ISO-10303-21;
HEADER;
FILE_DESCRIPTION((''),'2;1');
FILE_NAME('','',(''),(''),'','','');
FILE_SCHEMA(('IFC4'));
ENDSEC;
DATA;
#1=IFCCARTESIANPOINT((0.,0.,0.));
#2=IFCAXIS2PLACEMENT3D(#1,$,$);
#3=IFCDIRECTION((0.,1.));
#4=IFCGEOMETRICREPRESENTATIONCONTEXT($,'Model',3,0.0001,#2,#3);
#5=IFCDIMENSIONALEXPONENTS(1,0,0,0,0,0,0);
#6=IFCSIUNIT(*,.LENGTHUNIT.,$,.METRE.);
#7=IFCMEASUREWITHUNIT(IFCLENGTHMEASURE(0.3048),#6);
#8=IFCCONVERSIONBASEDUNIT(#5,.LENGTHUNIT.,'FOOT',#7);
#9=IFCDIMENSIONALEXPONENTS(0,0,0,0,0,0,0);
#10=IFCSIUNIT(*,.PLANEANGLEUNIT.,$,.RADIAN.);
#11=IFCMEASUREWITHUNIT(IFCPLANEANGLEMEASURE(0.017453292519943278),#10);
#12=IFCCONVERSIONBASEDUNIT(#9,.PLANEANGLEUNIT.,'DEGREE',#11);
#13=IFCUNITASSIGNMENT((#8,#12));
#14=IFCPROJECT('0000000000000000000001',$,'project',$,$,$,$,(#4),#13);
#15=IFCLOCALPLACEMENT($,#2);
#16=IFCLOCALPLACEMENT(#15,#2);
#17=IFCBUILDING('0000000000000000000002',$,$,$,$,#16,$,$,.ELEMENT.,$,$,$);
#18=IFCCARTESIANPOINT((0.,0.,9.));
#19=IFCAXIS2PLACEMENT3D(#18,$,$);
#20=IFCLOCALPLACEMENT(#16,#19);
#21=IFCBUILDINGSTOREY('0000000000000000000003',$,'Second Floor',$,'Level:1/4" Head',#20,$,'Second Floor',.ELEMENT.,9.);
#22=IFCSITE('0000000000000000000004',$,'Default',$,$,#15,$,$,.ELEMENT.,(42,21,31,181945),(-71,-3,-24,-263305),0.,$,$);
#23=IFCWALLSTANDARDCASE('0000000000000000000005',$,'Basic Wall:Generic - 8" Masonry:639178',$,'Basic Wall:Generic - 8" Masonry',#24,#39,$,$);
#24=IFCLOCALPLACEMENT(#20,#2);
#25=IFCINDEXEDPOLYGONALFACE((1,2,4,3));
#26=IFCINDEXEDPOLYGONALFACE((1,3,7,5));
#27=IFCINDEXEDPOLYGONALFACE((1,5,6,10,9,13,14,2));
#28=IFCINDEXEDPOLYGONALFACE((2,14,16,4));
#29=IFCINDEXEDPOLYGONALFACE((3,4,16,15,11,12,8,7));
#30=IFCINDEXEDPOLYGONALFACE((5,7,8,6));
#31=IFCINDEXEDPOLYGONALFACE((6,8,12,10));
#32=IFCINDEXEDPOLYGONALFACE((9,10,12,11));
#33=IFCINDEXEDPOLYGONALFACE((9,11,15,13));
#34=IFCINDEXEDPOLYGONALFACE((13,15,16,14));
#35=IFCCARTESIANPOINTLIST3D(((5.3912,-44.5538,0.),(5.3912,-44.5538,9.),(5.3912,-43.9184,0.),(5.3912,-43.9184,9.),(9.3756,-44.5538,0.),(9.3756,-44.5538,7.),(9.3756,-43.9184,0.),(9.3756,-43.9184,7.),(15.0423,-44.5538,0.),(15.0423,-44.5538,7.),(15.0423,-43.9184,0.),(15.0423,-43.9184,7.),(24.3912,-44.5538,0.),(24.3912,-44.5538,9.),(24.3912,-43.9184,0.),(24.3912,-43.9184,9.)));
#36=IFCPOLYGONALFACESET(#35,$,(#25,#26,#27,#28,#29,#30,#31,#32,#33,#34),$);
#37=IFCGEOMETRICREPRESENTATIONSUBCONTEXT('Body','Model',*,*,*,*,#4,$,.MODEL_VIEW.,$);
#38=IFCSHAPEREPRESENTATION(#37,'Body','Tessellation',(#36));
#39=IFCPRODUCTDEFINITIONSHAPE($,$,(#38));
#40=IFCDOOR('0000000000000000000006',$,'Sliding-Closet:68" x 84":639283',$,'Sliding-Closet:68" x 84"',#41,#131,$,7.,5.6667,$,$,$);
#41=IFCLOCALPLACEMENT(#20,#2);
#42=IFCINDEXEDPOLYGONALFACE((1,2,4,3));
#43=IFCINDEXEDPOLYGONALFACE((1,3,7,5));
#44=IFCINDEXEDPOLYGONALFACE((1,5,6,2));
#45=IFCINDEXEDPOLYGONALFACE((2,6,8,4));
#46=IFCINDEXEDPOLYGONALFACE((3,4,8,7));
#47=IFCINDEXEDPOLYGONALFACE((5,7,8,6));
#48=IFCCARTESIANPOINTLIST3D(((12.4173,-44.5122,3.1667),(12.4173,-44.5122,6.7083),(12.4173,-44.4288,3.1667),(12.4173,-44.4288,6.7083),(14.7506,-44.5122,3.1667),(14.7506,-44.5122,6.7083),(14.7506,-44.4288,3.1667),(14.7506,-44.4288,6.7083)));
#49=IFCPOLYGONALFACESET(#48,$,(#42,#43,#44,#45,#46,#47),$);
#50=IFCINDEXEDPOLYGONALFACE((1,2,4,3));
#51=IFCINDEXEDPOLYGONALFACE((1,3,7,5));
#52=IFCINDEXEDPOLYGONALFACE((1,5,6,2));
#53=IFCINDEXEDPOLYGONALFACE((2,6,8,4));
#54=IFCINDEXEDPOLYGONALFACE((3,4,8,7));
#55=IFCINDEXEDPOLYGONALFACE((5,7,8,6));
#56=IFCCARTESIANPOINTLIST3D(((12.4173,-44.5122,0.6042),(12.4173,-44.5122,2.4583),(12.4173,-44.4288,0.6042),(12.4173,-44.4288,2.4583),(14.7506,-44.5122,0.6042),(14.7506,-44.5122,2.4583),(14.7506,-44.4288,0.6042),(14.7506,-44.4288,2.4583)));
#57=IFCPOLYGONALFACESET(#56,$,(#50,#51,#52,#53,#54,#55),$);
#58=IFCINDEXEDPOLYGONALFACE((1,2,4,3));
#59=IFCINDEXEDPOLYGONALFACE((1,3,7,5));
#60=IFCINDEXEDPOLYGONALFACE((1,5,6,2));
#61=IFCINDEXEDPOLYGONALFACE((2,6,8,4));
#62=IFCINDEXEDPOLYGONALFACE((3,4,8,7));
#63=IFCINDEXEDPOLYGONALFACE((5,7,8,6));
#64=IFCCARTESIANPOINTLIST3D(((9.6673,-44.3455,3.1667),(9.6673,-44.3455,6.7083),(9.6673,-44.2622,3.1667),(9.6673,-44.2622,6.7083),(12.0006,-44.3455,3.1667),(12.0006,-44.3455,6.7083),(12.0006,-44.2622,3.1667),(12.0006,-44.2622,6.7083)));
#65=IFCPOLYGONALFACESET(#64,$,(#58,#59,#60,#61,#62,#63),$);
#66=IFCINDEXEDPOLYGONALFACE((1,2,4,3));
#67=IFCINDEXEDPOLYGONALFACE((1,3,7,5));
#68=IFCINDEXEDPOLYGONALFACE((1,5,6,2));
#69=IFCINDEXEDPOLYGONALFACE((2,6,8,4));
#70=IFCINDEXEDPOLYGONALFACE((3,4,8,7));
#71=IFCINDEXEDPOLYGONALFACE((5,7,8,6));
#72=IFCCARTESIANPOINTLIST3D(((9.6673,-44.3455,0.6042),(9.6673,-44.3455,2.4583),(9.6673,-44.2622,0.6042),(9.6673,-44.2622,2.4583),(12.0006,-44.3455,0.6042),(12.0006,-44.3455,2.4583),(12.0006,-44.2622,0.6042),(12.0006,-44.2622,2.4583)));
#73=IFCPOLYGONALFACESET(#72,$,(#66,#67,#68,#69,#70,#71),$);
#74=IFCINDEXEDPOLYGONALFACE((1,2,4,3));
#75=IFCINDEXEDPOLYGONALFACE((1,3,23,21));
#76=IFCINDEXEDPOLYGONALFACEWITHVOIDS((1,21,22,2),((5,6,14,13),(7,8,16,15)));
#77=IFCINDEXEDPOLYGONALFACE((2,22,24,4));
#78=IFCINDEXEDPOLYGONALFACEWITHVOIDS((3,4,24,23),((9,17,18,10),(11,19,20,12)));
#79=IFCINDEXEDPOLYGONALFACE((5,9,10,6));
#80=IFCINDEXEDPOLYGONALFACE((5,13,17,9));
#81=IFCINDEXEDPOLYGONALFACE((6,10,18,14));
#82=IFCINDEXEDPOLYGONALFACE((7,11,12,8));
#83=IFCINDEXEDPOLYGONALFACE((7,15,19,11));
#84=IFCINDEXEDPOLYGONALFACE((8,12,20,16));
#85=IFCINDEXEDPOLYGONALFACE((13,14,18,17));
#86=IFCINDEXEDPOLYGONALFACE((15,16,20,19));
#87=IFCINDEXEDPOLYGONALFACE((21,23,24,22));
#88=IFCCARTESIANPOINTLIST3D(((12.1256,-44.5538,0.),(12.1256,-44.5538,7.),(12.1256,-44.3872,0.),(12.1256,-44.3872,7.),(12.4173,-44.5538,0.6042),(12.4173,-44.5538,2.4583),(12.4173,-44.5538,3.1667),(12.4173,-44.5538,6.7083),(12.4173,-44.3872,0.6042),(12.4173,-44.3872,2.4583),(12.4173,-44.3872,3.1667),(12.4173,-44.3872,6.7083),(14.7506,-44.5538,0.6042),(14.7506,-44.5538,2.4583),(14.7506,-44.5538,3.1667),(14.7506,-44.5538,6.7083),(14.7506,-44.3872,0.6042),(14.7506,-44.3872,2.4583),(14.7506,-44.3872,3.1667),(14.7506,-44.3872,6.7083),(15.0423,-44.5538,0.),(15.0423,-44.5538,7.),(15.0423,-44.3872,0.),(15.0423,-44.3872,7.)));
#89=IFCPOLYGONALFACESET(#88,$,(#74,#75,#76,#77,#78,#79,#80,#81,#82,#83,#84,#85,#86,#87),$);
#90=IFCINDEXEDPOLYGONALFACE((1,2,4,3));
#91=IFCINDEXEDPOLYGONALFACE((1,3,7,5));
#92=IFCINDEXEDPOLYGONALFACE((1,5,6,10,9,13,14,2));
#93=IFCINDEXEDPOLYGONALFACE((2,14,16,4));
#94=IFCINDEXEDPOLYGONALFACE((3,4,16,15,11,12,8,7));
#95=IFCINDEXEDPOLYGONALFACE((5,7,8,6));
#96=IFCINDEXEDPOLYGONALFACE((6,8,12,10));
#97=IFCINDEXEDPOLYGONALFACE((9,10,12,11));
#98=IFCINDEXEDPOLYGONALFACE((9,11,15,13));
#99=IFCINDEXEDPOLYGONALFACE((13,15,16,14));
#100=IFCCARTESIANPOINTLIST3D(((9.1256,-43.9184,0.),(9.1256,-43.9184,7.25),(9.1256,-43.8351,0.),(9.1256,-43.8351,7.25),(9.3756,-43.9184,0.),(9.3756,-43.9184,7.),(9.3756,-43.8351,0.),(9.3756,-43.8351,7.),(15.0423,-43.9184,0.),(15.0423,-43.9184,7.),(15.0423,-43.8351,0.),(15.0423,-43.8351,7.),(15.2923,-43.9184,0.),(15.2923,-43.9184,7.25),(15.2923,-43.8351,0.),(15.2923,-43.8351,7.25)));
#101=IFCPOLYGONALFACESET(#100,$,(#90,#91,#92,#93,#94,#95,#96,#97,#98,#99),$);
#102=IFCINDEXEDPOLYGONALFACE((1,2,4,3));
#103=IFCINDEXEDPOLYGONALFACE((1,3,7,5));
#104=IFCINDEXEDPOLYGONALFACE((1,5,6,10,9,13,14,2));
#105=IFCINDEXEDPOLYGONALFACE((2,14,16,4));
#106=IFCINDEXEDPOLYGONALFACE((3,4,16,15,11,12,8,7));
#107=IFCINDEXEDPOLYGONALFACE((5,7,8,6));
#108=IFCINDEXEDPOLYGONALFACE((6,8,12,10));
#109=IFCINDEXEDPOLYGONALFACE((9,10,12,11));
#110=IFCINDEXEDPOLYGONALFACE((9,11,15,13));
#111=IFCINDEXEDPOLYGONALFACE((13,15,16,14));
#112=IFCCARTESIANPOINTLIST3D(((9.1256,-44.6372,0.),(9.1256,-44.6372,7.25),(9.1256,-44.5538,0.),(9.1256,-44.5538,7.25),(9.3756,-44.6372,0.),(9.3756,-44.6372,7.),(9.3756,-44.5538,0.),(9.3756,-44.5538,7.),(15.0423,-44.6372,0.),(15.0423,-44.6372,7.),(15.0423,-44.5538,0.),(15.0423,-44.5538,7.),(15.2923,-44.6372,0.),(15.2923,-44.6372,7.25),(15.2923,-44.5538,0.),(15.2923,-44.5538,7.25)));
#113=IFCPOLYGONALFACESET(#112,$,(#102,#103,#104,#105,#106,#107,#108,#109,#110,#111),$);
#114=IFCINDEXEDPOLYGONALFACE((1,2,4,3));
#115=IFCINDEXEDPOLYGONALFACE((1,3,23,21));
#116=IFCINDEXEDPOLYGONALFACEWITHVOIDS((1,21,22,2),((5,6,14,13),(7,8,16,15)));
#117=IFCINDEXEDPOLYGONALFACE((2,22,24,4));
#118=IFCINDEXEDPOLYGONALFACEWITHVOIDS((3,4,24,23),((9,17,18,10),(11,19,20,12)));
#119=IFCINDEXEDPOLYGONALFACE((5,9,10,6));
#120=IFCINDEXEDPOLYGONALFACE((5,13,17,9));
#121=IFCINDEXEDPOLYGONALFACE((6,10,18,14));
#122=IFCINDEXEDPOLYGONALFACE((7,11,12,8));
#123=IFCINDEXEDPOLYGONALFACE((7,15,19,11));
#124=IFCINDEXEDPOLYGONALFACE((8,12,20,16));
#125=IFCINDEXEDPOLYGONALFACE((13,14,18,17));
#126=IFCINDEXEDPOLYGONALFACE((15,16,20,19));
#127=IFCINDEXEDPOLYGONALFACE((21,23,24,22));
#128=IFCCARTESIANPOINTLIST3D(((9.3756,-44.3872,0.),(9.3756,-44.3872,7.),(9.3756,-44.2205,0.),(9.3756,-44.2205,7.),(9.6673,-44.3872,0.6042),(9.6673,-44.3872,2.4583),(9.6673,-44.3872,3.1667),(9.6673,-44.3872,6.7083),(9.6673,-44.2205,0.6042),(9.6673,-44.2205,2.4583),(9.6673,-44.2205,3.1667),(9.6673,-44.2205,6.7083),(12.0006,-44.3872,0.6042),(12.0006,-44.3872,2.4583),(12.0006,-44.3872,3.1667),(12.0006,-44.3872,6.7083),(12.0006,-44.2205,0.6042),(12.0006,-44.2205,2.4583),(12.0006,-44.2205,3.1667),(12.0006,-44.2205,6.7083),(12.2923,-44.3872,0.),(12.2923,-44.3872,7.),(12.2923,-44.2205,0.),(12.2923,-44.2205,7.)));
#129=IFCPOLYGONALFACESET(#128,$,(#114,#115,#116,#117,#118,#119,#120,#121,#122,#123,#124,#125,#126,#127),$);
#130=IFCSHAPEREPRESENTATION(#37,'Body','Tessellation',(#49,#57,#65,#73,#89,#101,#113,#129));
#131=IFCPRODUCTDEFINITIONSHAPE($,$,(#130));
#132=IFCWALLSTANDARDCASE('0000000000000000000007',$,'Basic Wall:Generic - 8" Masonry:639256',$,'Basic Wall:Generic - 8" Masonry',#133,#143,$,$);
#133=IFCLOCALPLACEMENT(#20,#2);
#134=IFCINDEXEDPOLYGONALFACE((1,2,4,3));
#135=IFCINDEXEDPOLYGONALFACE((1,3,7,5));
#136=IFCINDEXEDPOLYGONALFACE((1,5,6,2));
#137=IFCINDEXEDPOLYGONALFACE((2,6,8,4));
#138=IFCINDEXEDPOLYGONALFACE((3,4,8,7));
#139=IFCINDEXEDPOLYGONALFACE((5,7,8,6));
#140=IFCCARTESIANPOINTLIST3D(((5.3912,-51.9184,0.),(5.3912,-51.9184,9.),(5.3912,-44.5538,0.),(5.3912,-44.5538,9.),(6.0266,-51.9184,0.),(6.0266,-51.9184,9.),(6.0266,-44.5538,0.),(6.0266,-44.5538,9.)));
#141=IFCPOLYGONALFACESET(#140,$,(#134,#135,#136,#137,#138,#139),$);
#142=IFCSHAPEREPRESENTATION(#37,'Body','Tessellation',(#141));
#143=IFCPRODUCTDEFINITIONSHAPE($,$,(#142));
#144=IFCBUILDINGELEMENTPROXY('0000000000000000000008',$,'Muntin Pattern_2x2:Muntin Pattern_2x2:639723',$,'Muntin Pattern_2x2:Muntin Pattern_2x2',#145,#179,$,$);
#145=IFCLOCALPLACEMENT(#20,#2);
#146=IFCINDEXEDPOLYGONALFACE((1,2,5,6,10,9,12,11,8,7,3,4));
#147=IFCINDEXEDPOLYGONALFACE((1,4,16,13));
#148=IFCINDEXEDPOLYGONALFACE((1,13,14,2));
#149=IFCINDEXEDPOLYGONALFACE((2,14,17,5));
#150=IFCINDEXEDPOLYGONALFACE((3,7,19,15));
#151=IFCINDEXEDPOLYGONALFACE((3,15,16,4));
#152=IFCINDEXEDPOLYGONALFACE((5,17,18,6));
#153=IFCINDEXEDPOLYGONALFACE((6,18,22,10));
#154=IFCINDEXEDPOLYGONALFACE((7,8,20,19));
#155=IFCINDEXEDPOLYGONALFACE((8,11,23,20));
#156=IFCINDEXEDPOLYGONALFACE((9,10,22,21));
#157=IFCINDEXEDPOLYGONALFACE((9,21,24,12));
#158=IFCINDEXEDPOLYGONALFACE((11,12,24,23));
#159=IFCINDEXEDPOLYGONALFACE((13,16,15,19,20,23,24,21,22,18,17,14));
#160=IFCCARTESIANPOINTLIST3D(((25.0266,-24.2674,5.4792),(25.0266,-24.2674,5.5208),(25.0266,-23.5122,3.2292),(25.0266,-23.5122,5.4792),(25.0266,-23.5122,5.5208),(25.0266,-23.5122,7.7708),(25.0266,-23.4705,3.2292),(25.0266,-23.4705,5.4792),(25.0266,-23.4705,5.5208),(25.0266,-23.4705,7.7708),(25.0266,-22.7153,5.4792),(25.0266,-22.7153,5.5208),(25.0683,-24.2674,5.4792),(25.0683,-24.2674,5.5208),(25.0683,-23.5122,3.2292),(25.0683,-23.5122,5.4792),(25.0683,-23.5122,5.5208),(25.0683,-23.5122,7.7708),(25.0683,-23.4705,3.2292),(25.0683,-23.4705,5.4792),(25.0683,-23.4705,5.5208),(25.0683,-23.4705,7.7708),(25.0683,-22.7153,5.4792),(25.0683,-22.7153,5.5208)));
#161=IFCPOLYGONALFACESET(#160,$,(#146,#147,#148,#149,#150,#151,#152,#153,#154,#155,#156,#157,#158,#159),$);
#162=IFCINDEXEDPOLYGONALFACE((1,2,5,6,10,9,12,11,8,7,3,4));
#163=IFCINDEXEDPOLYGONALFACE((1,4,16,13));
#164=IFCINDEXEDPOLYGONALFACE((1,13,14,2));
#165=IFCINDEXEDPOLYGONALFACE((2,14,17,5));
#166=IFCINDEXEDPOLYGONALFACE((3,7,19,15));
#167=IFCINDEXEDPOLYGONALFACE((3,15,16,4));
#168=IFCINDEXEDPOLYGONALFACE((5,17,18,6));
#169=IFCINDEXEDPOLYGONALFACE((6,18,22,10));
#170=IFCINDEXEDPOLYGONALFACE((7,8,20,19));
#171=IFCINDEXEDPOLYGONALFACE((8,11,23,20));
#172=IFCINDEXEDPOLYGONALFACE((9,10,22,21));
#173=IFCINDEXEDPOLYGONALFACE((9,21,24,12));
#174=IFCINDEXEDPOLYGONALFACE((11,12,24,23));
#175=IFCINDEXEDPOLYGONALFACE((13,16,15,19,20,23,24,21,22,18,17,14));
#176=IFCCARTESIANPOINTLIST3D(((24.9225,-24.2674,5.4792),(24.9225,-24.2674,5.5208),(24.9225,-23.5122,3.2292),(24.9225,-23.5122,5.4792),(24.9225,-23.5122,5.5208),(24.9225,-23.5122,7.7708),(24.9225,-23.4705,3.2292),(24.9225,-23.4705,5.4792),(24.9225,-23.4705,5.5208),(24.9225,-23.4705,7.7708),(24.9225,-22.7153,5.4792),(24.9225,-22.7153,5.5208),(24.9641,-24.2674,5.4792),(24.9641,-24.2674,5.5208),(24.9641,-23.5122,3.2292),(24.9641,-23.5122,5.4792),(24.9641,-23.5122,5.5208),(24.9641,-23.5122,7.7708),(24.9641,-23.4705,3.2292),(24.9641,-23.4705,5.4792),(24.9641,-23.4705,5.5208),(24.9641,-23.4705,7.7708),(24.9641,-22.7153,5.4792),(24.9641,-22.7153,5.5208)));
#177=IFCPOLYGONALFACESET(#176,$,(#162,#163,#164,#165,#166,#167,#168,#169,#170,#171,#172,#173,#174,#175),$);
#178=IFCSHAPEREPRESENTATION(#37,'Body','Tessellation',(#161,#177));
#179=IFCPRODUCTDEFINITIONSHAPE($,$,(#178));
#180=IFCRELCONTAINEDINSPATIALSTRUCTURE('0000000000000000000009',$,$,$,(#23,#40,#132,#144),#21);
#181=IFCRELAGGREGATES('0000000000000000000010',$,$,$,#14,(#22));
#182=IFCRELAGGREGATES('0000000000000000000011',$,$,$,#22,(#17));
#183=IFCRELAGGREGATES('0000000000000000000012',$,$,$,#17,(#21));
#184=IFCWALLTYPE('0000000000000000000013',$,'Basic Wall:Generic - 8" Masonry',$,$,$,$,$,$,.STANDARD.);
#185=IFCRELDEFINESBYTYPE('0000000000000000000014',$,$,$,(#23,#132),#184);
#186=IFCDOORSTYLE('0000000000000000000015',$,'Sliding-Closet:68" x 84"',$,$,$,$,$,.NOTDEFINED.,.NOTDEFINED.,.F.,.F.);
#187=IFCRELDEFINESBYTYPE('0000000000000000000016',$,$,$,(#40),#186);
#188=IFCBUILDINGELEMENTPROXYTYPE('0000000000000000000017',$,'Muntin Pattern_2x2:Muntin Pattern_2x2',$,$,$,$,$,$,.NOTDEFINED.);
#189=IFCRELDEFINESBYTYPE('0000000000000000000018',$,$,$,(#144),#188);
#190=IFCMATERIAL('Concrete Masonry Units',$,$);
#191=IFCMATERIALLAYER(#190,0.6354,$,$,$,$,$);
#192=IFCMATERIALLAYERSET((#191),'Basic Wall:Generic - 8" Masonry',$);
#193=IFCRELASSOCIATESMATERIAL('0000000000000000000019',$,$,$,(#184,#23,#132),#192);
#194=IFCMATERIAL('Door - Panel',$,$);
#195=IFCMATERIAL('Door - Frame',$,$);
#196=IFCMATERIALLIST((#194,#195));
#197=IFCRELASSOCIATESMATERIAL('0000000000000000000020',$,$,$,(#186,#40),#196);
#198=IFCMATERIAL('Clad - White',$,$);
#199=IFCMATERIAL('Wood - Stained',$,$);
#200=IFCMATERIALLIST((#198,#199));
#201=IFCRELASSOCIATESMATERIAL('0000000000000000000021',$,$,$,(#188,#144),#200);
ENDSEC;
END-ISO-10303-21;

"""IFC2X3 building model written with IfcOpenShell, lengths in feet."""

from ifc_helpers import new_model, entity, si_unit, converted_unit, direction, frame, frame_2d, origin, origin_2d_with_axis, place, context, subcontext, project, spatial, polyline, rectangle, outline, extrude, source, transform, mapped, material, material_list, layer, layer_set, layer_usage, type_object, type_shapes, element, fill, save


model = new_model("IFC2X3")

# Units and contexts
model_context = context("Model", 3, precision=0.0001, world=origin(), true_north=direction((0.0, 1.0)))
body_context = subcontext(model_context, "Body", "Model", "MODEL_VIEW")
ifc_project = project(units=[converted_unit("LENGTHUNIT", "FOOT", entity("IfcLengthMeasure", 0.3048), si_unit("LENGTHUNIT", "METRE"), dimensions=[1, 0, 0, 0, 0, 0, 0]), converted_unit("PLANEANGLEUNIT", "DEGREE", entity("IfcPlaneAngleMeasure", 0.017453292519943278), si_unit("PLANEANGLEUNIT", "RADIAN"), dimensions=[0, 0, 0, 0, 0, 0, 0])], contexts=[model_context])

# Site, building, storey
site_placement = place(None, origin())
site = spatial("IfcSite", under=ifc_project, at=site_placement, Name="Default", CompositionType="ELEMENT", RefLatitude=(42, 21, 31, 181945), RefLongitude=(-71, -3, -24, -263305), RefElevation=0.0)
building_placement = place(site_placement, origin())
building = spatial("IfcBuilding", under=site, at=building_placement, CompositionType="ELEMENT")
storey_placement = place(building_placement, frame((0.0, 0.0, 9.0)))
storey = spatial("IfcBuildingStorey", under=building, at=storey_placement, Name="Second Floor", ObjectType="Level:1/4\" Head", LongName="Second Floor", CompositionType="ELEMENT", Elevation=9.0)

# Shared definitions
ifc_material_1 = material(Name="Concrete Masonry Units")
ifc_layer = layer(ifc_material_1, 0.6354)
ifc_layer_set = layer_set([ifc_layer], Name="Basic Wall:Generic - 8\" Masonry")
wall_type = type_object("IfcWallType", Name="Basic Wall:Generic - 8\" Masonry", PredefinedType="STANDARD", material=ifc_layer_set)

# Shared definitions
ifc_material_2 = material(Name="Door - Frame")
ifc_material_3 = material(Name="Door - Panel")

# Wall, opening, door
ifc_layer_usage_1 = layer_usage(ifc_layer_set, "AXIS2", "NEGATIVE", 0.3177)
wall_1_placement = place(storey_placement, frame((24.3912, -44.2361, 0.0), z_axis=(0.0, 0.0, 1.0), x_axis=(-1.0, 0.0, 0.0)))
wall_1 = element("IfcWallStandardCase", 1, at=wall_1_placement, inside=storey, type_object=wall_type, material=ifc_layer_usage_1, Name="Basic Wall:Generic - 8\" Masonry:639178", ObjectType="Basic Wall:Generic - 8\" Masonry", context=body_context, shape_type="SweptSolid", body=[
    extrude(rectangle(XDim=19.0, YDim=0.6354, at=frame_2d((9.5, 0.0), x_axis=(-1.0, 0.0))), origin(), (0.0, 0.0, 1.0), 9.0),
])
opening_1_placement = place(wall_1_placement, frame((9.349, -0.3177, 0.0)))
opening_1 = element("IfcOpeningElement", 2, at=opening_1_placement, cuts=wall_1, ObjectType="Opening", context=body_context, shape_type="SweptSolid", body=[
    extrude(rectangle(XDim=7.0, YDim=5.6667, at=frame_2d((3.5, 2.8333), x_axis=(-1.0, 0.0))), frame((0.0, 0.0, 0.0), z_axis=(0.0, 1.0, 0.0), x_axis=(0.0, 0.0, 1.0)), (0.0, 0.0, 1.0), 0.6354),
])
ifc_material_list_1 = material_list([ifc_material_3, ifc_material_2])
door_style_1 = type_object("IfcDoorStyle", Name="Sliding-Closet:68\" x 84\"", ConstructionType="NOTDEFINED", OperationType="NOTDEFINED", ParameterTakesPrecedence=False, Sizeable=False, material=ifc_material_list_1)
shared_shape_1 = source(origin(), body_context, "Body", "SweptSolid", [
    extrude(rectangle(XDim=0.0833, YDim=2.3333, at=origin_2d_with_axis()), frame((1.4583, 0.5521, 3.1667), z_axis=(0.0, 0.0, 1.0), x_axis=(0.0, 1.0, 0.0)), (0.0, 0.0, 1.0), 3.5417),
    extrude(rectangle(XDim=0.0833, YDim=2.3333, at=origin_2d_with_axis()), frame((1.4583, 0.5521, 0.6042), z_axis=(0.0, 0.0, 1.0), x_axis=(0.0, 1.0, 0.0)), (0.0, 0.0, 1.0), 1.8542),
    extrude(rectangle(XDim=0.0833, YDim=2.3333, at=origin_2d_with_axis()), frame((4.2083, 0.3854, 3.1667), z_axis=(0.0, 0.0, 1.0), x_axis=(0.0, -1.0, 0.0)), (0.0, 0.0, 1.0), 3.5417),
    extrude(rectangle(XDim=0.0833, YDim=2.3333, at=origin_2d_with_axis()), frame((4.2083, 0.3854, 0.6042), z_axis=(0.0, 0.0, 1.0), x_axis=(0.0, -1.0, 0.0)), (0.0, 0.0, 1.0), 1.8542),
    extrude(outline(polyline([(-3.5, -1.4583), (3.5, -1.4583), (3.5, 1.4583), (-3.5, 1.4583), (-3.5, -1.4583)]), holes=[polyline([(2.8958, 1.1667), (2.8958, -1.1667), (1.0417, -1.1667), (1.0417, 1.1667), (2.8958, 1.1667)]), polyline([(0.3333, 1.1667), (0.3333, -1.1667), (-3.2083, -1.1667), (-3.2083, 1.1667), (0.3333, 1.1667)])]), frame((1.4583, 0.4688, 3.5), z_axis=(0.0, 1.0, 0.0), x_axis=(0.0, 0.0, -1.0)), (0.0, 0.0, 1.0), 0.1667),
    extrude(outline(polyline([(-3.5625, -3.0833), (3.6875, -3.0833), (3.6875, 3.0833), (-3.5625, 3.0833), (-3.5625, 2.8333), (3.4375, 2.8333), (3.4375, -2.8333), (-3.5625, -2.8333), (-3.5625, -3.0833)])), frame((2.8333, -0.0833, 3.5625), z_axis=(0.0, 1.0, 0.0), x_axis=(0.0, 0.0, 1.0)), (0.0, 0.0, 1.0), 0.0833),
    extrude(outline(polyline([(-3.0833, -3.5625), (-2.8333, -3.5625), (-2.8333, 3.4375), (2.8333, 3.4375), (2.8333, -3.5625), (3.0833, -3.5625), (3.0833, 3.6875), (-3.0833, 3.6875), (-3.0833, -3.5625)])), frame((2.8333, 0.6354, 3.5625), z_axis=(0.0, 1.0, 0.0), x_axis=(-1.0, 0.0, 0.0)), (0.0, 0.0, 1.0), 0.0833),
    extrude(outline(polyline([(-1.4583, -3.5), (1.4583, -3.5), (1.4583, 3.5), (-1.4583, 3.5), (-1.4583, -3.5)]), holes=[polyline([(1.1667, 0.3333), (1.1667, -3.2083), (-1.1667, -3.2083), (-1.1667, 0.3333), (1.1667, 0.3333)]), polyline([(1.1667, 2.8958), (1.1667, 1.0417), (-1.1667, 1.0417), (-1.1667, 2.8958), (1.1667, 2.8958)])]), frame((4.2083, 0.3021, 3.5), z_axis=(0.0, 1.0, 0.0), x_axis=(1.0, 0.0, 0.0)), (0.0, 0.0, 1.0), 0.1667),
])
type_shapes(door_style_1, [shared_shape_1])
door_1_placement = place(opening_1_placement, origin())
door_1 = element("IfcDoor", 3, at=door_1_placement, inside=storey, type_object=door_style_1, material=ifc_material_list_1, Name="Sliding-Closet:68\" x 84\":639283", ObjectType="Sliding-Closet:68\" x 84\"", OverallHeight=7.0, OverallWidth=5.6667, context=body_context, shape_type="MappedRepresentation", body=[
    mapped(shared_shape_1, transform((0.0, 0.0, 0.0), scale=1.0)),
])
fill(opening_1, door_1)

# Wall
ifc_layer_usage_2 = layer_usage(ifc_layer_set, "AXIS2", "NEGATIVE", 0.3177)
wall_2_placement = place(storey_placement, frame((5.7089, -44.5538, 0.0), z_axis=(0.0, 0.0, 1.0), x_axis=(0.0, -1.0, 0.0)))
element("IfcWallStandardCase", 4, at=wall_2_placement, inside=storey, type_object=wall_type, material=ifc_layer_usage_2, Name="Basic Wall:Generic - 8\" Masonry:639256", ObjectType="Basic Wall:Generic - 8\" Masonry", context=body_context, shape_type="SweptSolid", body=[
    extrude(rectangle(XDim=7.3646, YDim=0.6354, at=frame_2d((3.6823, 0.0), x_axis=(-1.0, 0.0))), origin(), (0.0, 0.0, 1.0), 9.0),
])

# Building element proxy
ifc_material_4 = material(Name="Clad - White")
ifc_material_5 = material(Name="Wood - Stained")
ifc_material_list_2 = material_list([ifc_material_4, ifc_material_5])
building_element_proxy_type_1 = type_object("IfcBuildingElementProxyType", Name="Muntin Pattern_2x2:Muntin Pattern_2x2", PredefinedType="NOTDEFINED", material=ifc_material_list_2)
shared_shape_2 = source(origin(), body_context, "Body", "SweptSolid", [
    extrude(outline(polyline([(0.0208, -0.0208), (2.2708, -0.0208), (2.2708, 0.0208), (0.0208, 0.0208), (0.0208, 0.776), (-0.0208, 0.776), (-0.0208, 0.0208), (-2.2708, 0.0208), (-2.2708, -0.0208), (-0.0208, -0.0208), (-0.0208, -0.776), (0.0208, -0.776), (0.0208, -0.0208)])), frame((0.0, 0.0313, 2.2708), z_axis=(0.0, 1.0, 0.0), x_axis=(0.0, 0.0, 1.0)), (0.0, 0.0, 1.0), 0.0417),
    extrude(outline(polyline([(0.0208, -0.0208), (2.2708, -0.0208), (2.2708, 0.0208), (0.0208, 0.0208), (0.0208, 0.776), (-0.0208, 0.776), (-0.0208, 0.0208), (-2.2708, 0.0208), (-2.2708, -0.0208), (-0.0208, -0.0208), (-0.0208, -0.776), (0.0208, -0.776), (0.0208, -0.0208)])), frame((0.0, -0.0729, 2.2708), z_axis=(0.0, 1.0, 0.0), x_axis=(0.0, 0.0, 1.0)), (0.0, 0.0, 1.0), 0.0417),
])
type_shapes(building_element_proxy_type_1, [shared_shape_2])
proxy_1_placement = place(storey_placement, frame((24.9954, -23.4913, 3.2292), z_axis=(0.0, 0.0, 1.0), x_axis=(0.0, -1.0, 0.0)))
element("IfcBuildingElementProxy", 5, at=proxy_1_placement, inside=storey, type_object=building_element_proxy_type_1, material=ifc_material_list_2, Name="Muntin Pattern_2x2:Muntin Pattern_2x2:639723", ObjectType="Muntin Pattern_2x2:Muntin Pattern_2x2", context=body_context, shape_type="MappedRepresentation", body=[
    mapped(shared_shape_2, transform((0.0, 0.0, 0.0), scale=1.0)),
])

save(model, "model.ifc")
